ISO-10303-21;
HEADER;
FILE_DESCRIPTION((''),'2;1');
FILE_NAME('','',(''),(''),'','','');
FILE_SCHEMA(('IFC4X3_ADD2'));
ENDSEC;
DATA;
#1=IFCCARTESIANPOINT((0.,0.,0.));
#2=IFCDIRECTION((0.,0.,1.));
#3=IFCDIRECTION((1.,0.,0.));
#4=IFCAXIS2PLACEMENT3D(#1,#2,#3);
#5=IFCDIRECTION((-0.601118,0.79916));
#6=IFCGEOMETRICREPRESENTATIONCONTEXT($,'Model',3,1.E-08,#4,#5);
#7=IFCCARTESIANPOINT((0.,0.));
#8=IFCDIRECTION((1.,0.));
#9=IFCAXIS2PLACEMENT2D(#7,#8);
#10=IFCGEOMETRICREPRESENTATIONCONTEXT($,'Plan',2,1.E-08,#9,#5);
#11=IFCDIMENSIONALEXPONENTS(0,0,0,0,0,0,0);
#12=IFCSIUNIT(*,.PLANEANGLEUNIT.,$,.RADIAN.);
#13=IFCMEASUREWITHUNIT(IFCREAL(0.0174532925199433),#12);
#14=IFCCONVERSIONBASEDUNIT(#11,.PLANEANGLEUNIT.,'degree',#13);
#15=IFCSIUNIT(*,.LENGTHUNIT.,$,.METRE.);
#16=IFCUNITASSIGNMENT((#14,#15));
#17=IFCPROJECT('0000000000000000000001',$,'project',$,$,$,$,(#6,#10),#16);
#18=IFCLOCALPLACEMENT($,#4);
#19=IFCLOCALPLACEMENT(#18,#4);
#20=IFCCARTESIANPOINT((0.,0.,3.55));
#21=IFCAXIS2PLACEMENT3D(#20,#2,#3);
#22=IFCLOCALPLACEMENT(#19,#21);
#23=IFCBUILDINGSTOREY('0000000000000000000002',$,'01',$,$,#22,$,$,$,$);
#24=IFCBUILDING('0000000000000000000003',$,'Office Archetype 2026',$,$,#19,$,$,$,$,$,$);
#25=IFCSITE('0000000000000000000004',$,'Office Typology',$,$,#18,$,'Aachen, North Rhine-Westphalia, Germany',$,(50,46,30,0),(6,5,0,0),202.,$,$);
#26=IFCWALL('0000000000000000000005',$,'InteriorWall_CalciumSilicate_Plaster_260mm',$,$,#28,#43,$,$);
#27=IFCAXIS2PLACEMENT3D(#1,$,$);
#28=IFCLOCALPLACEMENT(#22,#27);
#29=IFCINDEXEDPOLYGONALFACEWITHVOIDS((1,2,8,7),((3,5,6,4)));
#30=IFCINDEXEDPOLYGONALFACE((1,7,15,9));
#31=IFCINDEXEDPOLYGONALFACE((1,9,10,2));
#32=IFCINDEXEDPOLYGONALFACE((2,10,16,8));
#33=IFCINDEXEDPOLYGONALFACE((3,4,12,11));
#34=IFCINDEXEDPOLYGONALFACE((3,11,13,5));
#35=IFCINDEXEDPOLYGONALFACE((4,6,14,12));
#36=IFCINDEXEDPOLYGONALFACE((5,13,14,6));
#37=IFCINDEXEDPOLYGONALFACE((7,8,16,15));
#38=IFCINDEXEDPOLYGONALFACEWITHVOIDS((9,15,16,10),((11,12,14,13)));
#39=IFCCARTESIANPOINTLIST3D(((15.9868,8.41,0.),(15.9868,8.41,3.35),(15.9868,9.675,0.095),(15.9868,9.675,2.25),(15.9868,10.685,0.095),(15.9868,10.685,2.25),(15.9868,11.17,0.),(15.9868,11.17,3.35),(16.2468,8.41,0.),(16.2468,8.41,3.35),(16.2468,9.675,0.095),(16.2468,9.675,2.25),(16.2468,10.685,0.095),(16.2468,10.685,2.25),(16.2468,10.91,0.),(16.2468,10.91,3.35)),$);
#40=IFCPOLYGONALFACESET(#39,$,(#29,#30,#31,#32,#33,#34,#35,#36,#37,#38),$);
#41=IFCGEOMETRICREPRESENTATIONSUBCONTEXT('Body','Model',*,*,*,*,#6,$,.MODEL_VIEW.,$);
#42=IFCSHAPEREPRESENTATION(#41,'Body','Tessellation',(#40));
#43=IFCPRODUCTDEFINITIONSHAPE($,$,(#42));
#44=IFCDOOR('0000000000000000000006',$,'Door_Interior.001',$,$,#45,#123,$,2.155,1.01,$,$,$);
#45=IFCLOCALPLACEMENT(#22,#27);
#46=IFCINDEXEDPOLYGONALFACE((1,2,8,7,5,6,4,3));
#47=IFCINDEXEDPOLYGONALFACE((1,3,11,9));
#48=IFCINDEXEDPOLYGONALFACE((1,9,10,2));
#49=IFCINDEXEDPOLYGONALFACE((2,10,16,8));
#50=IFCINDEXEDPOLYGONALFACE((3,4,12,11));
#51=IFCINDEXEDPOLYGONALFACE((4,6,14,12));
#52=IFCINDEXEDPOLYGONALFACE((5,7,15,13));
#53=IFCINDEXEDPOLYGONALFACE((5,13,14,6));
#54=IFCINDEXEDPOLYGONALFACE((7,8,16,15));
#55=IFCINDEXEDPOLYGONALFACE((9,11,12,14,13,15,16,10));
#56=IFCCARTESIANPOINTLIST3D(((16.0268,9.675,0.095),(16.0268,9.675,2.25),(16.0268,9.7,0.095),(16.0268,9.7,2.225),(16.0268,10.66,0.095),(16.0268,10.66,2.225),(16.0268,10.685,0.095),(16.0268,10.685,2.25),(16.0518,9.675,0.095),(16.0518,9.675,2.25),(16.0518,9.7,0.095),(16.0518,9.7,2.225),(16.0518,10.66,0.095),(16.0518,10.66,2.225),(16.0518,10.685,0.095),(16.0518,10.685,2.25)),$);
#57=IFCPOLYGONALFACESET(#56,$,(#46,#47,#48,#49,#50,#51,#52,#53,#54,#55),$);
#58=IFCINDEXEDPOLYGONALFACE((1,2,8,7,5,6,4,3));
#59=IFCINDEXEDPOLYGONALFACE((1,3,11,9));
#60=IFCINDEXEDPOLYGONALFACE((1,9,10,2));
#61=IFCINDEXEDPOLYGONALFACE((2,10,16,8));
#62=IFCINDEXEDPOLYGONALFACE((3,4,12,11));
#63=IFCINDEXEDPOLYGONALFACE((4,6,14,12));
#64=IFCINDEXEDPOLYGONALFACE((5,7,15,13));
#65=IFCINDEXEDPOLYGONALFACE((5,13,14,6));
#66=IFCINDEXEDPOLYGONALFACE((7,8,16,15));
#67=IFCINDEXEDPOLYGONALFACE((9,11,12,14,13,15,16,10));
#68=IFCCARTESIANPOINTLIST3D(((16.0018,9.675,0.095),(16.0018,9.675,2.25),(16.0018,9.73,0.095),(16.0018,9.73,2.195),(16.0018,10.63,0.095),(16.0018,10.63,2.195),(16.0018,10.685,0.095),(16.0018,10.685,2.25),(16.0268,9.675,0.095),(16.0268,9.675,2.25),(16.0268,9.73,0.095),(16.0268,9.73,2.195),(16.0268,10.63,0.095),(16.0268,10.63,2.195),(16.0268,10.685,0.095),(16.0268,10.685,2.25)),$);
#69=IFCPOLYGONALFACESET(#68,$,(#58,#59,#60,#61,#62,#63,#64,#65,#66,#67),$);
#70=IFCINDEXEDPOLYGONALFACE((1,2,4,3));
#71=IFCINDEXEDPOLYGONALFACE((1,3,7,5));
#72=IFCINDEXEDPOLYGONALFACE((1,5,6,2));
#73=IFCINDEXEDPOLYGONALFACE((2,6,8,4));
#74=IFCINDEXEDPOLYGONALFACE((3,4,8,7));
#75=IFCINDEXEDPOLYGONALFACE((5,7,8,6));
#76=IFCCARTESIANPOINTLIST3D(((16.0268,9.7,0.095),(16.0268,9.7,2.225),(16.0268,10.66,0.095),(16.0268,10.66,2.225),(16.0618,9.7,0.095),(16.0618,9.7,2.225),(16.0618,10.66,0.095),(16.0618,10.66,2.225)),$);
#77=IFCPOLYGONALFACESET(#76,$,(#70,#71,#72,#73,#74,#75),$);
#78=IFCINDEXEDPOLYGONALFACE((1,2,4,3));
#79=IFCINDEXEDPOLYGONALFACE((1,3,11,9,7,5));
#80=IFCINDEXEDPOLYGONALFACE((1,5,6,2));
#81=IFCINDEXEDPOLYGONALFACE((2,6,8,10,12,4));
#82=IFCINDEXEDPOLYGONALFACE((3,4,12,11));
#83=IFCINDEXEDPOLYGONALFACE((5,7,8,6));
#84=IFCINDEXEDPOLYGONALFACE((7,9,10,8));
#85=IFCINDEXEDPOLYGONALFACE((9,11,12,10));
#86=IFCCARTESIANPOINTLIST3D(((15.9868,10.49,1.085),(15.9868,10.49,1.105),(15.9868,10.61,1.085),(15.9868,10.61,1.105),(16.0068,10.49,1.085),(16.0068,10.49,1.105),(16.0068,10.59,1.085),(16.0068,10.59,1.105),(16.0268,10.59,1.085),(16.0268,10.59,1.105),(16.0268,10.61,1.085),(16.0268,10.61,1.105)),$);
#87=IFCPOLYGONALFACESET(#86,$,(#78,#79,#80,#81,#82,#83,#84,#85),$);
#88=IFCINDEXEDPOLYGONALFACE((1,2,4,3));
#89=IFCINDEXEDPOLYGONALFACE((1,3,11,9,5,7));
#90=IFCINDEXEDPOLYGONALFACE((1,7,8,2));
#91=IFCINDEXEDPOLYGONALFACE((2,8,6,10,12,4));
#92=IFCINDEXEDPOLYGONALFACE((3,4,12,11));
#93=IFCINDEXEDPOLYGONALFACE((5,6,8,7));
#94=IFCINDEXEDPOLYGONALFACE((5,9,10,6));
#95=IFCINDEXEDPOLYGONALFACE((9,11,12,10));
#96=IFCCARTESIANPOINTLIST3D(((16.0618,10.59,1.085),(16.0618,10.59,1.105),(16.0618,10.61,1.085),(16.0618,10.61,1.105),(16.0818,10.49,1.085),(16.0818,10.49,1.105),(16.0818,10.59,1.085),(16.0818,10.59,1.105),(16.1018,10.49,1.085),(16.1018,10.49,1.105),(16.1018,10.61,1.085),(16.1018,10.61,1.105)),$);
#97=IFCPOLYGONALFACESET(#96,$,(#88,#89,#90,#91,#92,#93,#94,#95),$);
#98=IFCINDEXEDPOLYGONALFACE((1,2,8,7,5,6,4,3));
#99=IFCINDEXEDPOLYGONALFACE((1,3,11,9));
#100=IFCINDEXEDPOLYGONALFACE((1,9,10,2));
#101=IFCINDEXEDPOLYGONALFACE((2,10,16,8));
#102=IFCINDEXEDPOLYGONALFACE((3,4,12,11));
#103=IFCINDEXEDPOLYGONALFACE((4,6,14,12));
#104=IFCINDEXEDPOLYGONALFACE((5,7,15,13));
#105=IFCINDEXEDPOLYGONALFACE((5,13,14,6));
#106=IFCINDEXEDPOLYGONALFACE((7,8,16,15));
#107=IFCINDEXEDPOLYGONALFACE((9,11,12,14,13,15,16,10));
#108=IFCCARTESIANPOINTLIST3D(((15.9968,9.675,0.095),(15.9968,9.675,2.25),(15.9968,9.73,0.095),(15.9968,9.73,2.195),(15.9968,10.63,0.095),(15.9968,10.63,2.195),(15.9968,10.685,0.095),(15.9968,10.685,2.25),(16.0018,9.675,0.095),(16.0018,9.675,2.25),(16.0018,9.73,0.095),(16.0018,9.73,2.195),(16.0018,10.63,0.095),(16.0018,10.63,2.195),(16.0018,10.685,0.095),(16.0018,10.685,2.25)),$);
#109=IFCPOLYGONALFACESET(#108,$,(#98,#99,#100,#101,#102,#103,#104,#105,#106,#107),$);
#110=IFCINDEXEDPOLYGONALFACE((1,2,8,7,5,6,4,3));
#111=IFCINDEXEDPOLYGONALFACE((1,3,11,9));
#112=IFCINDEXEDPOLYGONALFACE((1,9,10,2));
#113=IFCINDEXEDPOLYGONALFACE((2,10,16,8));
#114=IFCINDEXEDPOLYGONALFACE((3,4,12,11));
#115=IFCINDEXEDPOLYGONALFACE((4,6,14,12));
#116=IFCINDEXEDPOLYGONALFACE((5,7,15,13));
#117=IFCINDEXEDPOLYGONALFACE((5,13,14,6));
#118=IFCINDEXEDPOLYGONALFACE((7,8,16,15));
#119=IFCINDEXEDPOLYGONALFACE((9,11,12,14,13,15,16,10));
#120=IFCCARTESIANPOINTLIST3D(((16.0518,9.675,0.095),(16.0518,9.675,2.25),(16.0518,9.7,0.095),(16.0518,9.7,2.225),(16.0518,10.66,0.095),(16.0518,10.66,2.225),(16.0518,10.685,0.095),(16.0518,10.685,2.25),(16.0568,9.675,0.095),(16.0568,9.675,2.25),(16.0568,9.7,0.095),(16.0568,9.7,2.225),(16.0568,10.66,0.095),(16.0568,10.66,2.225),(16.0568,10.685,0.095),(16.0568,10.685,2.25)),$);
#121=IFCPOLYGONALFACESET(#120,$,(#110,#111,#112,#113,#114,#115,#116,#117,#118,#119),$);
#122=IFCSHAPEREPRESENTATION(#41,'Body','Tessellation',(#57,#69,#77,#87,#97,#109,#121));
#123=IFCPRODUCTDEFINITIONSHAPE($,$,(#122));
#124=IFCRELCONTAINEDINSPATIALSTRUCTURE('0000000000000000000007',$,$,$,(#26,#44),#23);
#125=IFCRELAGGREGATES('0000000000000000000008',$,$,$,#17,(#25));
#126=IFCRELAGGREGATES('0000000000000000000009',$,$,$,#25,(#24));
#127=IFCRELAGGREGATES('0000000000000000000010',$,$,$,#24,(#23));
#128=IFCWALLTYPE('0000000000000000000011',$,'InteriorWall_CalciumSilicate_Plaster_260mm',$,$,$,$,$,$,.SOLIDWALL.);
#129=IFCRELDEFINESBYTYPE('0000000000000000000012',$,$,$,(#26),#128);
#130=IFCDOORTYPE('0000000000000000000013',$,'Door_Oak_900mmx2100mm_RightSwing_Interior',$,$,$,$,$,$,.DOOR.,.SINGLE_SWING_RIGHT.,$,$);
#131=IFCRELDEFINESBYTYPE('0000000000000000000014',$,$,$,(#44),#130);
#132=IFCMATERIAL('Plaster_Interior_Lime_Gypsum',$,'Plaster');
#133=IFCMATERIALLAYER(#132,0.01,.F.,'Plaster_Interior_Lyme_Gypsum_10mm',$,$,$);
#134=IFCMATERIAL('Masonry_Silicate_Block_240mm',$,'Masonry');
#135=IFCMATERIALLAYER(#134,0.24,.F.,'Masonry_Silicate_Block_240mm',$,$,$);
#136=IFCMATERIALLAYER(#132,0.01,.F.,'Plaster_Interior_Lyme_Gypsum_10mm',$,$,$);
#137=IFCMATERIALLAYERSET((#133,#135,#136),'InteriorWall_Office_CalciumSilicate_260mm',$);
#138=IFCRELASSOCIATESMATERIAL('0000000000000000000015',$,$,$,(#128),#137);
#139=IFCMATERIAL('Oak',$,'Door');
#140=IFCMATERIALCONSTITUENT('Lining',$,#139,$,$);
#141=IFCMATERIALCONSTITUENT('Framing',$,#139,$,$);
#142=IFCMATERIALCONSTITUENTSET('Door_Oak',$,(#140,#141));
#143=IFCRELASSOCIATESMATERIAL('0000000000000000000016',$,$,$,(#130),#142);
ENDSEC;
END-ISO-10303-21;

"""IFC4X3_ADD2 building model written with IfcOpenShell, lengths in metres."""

from ifc_helpers import new_model, entity, si_unit, converted_unit, direction, frame, origin_with_axes, origin_2d_with_axis, place, context, subcontext, project, spatial, line, indexed_curve, outline, extrude, source, transform, mapped, material, layer, layer_set, constituent, constituent_set, type_object, type_shapes, element, fill, save


model = new_model("IFC4X3_ADD2")

# Units and contexts
model_context = context("Model", 3, precision=1e-08, world=origin_with_axes(), true_north=direction((-0.601118, 0.79916)))
plan_context = context("Plan", 2, precision=1e-08, world=origin_2d_with_axis(), true_north=direction((-0.601118, 0.79916)))
body_context = subcontext(model_context, "Body", "Model", "MODEL_VIEW")
ifc_project = project(units=[converted_unit("PLANEANGLEUNIT", "degree", entity("IfcReal", 0.0174532925199433), si_unit("PLANEANGLEUNIT", "RADIAN"), dimensions=[0, 0, 0, 0, 0, 0, 0]), si_unit("LENGTHUNIT", "METRE")], contexts=[model_context, plan_context])

# Site, building, storey
site_placement = place(None, origin_with_axes())
site = spatial("IfcSite", under=ifc_project, at=site_placement, Name="Office Typology", LongName="Aachen, North Rhine-Westphalia, Germany", RefLatitude=(50, 46, 30, 0), RefLongitude=(6, 5, 0, 0), RefElevation=202.0)
building_placement = place(site_placement, origin_with_axes())
building = spatial("IfcBuilding", under=site, at=building_placement, Name="Office Archetype 2026")
storey_placement = place(building_placement, frame((0.0, 0.0, 3.55), z_axis=(0.0, 0.0, 1.0), x_axis=(1.0, 0.0, 0.0)))
storey = spatial("IfcBuildingStorey", under=building, at=storey_placement, Name="01")

# Wall, opening, door
ifc_material_1 = material(Name="Plaster_Interior_Lime_Gypsum", Category="Plaster")
ifc_layer_1 = layer(ifc_material_1, 0.01, ventilated=False, Name="Plaster_Interior_Lyme_Gypsum_10mm")
ifc_material_2 = material(Name="Masonry_Silicate_Block_240mm", Category="Masonry")
ifc_layer_2 = layer(ifc_material_2, 0.24, ventilated=False, Name="Masonry_Silicate_Block_240mm")
ifc_layer_3 = layer(ifc_material_1, 0.01, ventilated=False, Name="Plaster_Interior_Lyme_Gypsum_10mm")
ifc_layer_set_1 = layer_set([ifc_layer_1, ifc_layer_2, ifc_layer_3], Name="InteriorWall_Office_CalciumSilicate_260mm")
wall_type_1 = type_object("IfcWallType", Name="InteriorWall_CalciumSilicate_Plaster_260mm", PredefinedType="SOLIDWALL", material=ifc_layer_set_1)
wall_1_placement = place(storey_placement, frame((15.9868, 11.17, 0.0), z_axis=(0.0, 0.0, 1.0), x_axis=(0.0, -1.0, 0.0)))
wall_1 = element("IfcWall", 1, at=wall_1_placement, inside=storey, type_object=wall_type_1, Name="InteriorWall_CalciumSilicate_Plaster_260mm", context=body_context, shape_type="SweptSolid", body=[
    extrude(outline(indexed_curve([(0.0, 0.0), (0.26, 0.26), (2.76, 0.26), (2.76, 0.0)], segments=[line(1, 2, 3, 4, 1)])), origin_with_axes(), (0.0, 0.0, 1.0), 3.35),
])
shared_shape_1 = source(origin_with_axes(), body_context, "Body", "SweptSolid", [
    extrude(outline(indexed_curve([(0.0, 2.155), (1.01, 2.155), (1.01, 0.0), (0.0, 0.0), (0.0, 2.155)])), frame((0.0, 0.0, 0.0), z_axis=(0.0, -1.0, 0.0), x_axis=(1.0, 0.0, 0.0)), (0.0, 0.0, -1.0), 0.26),
])
opening_1_placement = place(wall_1_placement, frame((0.485, 0.0, 0.095), z_axis=(0.0, 0.0, 1.0), x_axis=(1.0, 0.0, 0.0)))
opening_1 = element("IfcOpeningElement", 2, at=opening_1_placement, cuts=wall_1, PredefinedType="OPENING", context=body_context, shape_type="MappedRepresentation", body=[
    mapped(shared_shape_1, transform((0.0, 0.0, 0.0), x_axis=(1.0, 0.0, 0.0), y_axis=(0.0, 1.0, 0.0), z_axis=(0.0, 0.0, 1.0), scale=1.0)),
])
ifc_material_3 = material(Name="Oak", Category="Door")
ifc_constituent_1 = constituent(ifc_material_3, Name="Lining")
ifc_constituent_2 = constituent(ifc_material_3, Name="Framing")
ifc_constituent_set_1 = constituent_set(constituents=[ifc_constituent_1, ifc_constituent_2], Name="Door_Oak")
door_type = type_object("IfcDoorType", Name="Door_Oak_900mmx2100mm_RightSwing_Interior", OperationType="SINGLE_SWING_RIGHT", PredefinedType="DOOR", material=ifc_constituent_set_1)
shared_shape_2 = source(origin_with_axes(), body_context, "Body", "SweptSolid", [
    extrude(outline(indexed_curve([(0.0, 0.0), (0.0, 2.155), (1.01, 2.155), (1.01, 0.0), (0.985, 0.0), (0.985, 2.13), (0.025, 2.13), (0.025, 0.0)], segments=[line(1, 2, 3, 4, 5, 6, 7, 8, 1)])), frame((0.0, 0.025, 0.0), z_axis=(0.0, -1.0, 0.0), x_axis=(1.0, 0.0, 0.0)), (0.0, 0.0, -1.0), 0.025),
    extrude(outline(indexed_curve([(0.0, 0.0), (0.0, 2.155), (1.01, 2.155), (1.01, 0.0), (0.955, 0.0), (0.955, 2.1), (0.055, 2.1), (0.055, 0.0)], segments=[line(1, 2, 3, 4, 5, 6, 7, 8, 1)])), frame((0.0, 0.0, 0.0), z_axis=(0.0, -1.0, 0.0), x_axis=(1.0, 0.0, 0.0)), (0.0, 0.0, -1.0), 0.025),
    extrude(outline(indexed_curve([(0.0, 0.0), (0.96, 0.0), (0.96, 0.035), (0.0, 0.035)], segments=[line(1, 2, 3, 4, 1)])), frame((0.025, 0.025, 0.0), z_axis=(0.0, 0.0, 1.0), x_axis=(1.0, 0.0, 0.0)), (0.0, 0.0, 1.0), 2.13),
    extrude(outline(indexed_curve([(0.0, 0.0), (0.0, -0.04), (0.12, -0.04), (0.12, -0.02), (0.02, -0.02), (0.02, 0.0)], segments=[line(1, 2, 3, 4, 5, 6, 1)])), frame((0.075, 0.025, 0.99), z_axis=(0.0, 0.0, 1.0), x_axis=(1.0, 0.0, 0.0)), (0.0, 0.0, 1.0), 0.02),
    extrude(outline(indexed_curve([(0.0, 0.0), (0.0, 0.04), (0.12, 0.04), (0.12, 0.02), (0.02, 0.02), (0.02, 0.0)], segments=[line(1, 2, 3, 4, 5, 6, 1)])), frame((0.075, 0.06, 0.99), z_axis=(0.0, 0.0, 1.0), x_axis=(1.0, 0.0, 0.0)), (0.0, 0.0, 1.0), 0.02),
    extrude(outline(indexed_curve([(0.0, 0.0), (0.0, 2.155), (1.01, 2.155), (1.01, 0.0), (0.955, 0.0), (0.955, 2.1), (0.055, 2.1), (0.055, 0.0)], segments=[line(1, 2, 3, 4, 5, 6, 7, 8, 1)])), frame((0.0, -0.005, 0.0), z_axis=(0.0, -1.0, 0.0), x_axis=(1.0, 0.0, 0.0)), (0.0, 0.0, -1.0), 0.005),
    extrude(outline(indexed_curve([(0.0, 0.0), (0.0, 2.155), (1.01, 2.155), (1.01, 0.0), (0.985, 0.0), (0.985, 2.13), (0.025, 2.13), (0.025, 0.0)], segments=[line(1, 2, 3, 4, 5, 6, 7, 8, 1)])), frame((0.0, 0.05, 0.0), z_axis=(0.0, -1.0, 0.0), x_axis=(1.0, 0.0, 0.0)), (0.0, 0.0, -1.0), 0.005),
])
type_shapes(door_type, [shared_shape_2])
door_placement = place(opening_1_placement, frame((0.0, 0.015, 0.0), z_axis=(0.0, 0.0, 1.0), x_axis=(1.0, 0.0, 0.0)))
door = element("IfcDoor", 3, at=door_placement, inside=storey, type_object=door_type, Name="Door_Interior.001", OverallHeight=2.155, OverallWidth=1.01, context=body_context, shape_type="MappedRepresentation", body=[
    mapped(shared_shape_2, transform((0.0, 0.0, 0.0), x_axis=(1.0, 0.0, 0.0), y_axis=(0.0, 1.0, 0.0), z_axis=(0.0, 0.0, 1.0), scale=1.0)),
])
fill(opening_1, door)

save(model, "model.ifc")
